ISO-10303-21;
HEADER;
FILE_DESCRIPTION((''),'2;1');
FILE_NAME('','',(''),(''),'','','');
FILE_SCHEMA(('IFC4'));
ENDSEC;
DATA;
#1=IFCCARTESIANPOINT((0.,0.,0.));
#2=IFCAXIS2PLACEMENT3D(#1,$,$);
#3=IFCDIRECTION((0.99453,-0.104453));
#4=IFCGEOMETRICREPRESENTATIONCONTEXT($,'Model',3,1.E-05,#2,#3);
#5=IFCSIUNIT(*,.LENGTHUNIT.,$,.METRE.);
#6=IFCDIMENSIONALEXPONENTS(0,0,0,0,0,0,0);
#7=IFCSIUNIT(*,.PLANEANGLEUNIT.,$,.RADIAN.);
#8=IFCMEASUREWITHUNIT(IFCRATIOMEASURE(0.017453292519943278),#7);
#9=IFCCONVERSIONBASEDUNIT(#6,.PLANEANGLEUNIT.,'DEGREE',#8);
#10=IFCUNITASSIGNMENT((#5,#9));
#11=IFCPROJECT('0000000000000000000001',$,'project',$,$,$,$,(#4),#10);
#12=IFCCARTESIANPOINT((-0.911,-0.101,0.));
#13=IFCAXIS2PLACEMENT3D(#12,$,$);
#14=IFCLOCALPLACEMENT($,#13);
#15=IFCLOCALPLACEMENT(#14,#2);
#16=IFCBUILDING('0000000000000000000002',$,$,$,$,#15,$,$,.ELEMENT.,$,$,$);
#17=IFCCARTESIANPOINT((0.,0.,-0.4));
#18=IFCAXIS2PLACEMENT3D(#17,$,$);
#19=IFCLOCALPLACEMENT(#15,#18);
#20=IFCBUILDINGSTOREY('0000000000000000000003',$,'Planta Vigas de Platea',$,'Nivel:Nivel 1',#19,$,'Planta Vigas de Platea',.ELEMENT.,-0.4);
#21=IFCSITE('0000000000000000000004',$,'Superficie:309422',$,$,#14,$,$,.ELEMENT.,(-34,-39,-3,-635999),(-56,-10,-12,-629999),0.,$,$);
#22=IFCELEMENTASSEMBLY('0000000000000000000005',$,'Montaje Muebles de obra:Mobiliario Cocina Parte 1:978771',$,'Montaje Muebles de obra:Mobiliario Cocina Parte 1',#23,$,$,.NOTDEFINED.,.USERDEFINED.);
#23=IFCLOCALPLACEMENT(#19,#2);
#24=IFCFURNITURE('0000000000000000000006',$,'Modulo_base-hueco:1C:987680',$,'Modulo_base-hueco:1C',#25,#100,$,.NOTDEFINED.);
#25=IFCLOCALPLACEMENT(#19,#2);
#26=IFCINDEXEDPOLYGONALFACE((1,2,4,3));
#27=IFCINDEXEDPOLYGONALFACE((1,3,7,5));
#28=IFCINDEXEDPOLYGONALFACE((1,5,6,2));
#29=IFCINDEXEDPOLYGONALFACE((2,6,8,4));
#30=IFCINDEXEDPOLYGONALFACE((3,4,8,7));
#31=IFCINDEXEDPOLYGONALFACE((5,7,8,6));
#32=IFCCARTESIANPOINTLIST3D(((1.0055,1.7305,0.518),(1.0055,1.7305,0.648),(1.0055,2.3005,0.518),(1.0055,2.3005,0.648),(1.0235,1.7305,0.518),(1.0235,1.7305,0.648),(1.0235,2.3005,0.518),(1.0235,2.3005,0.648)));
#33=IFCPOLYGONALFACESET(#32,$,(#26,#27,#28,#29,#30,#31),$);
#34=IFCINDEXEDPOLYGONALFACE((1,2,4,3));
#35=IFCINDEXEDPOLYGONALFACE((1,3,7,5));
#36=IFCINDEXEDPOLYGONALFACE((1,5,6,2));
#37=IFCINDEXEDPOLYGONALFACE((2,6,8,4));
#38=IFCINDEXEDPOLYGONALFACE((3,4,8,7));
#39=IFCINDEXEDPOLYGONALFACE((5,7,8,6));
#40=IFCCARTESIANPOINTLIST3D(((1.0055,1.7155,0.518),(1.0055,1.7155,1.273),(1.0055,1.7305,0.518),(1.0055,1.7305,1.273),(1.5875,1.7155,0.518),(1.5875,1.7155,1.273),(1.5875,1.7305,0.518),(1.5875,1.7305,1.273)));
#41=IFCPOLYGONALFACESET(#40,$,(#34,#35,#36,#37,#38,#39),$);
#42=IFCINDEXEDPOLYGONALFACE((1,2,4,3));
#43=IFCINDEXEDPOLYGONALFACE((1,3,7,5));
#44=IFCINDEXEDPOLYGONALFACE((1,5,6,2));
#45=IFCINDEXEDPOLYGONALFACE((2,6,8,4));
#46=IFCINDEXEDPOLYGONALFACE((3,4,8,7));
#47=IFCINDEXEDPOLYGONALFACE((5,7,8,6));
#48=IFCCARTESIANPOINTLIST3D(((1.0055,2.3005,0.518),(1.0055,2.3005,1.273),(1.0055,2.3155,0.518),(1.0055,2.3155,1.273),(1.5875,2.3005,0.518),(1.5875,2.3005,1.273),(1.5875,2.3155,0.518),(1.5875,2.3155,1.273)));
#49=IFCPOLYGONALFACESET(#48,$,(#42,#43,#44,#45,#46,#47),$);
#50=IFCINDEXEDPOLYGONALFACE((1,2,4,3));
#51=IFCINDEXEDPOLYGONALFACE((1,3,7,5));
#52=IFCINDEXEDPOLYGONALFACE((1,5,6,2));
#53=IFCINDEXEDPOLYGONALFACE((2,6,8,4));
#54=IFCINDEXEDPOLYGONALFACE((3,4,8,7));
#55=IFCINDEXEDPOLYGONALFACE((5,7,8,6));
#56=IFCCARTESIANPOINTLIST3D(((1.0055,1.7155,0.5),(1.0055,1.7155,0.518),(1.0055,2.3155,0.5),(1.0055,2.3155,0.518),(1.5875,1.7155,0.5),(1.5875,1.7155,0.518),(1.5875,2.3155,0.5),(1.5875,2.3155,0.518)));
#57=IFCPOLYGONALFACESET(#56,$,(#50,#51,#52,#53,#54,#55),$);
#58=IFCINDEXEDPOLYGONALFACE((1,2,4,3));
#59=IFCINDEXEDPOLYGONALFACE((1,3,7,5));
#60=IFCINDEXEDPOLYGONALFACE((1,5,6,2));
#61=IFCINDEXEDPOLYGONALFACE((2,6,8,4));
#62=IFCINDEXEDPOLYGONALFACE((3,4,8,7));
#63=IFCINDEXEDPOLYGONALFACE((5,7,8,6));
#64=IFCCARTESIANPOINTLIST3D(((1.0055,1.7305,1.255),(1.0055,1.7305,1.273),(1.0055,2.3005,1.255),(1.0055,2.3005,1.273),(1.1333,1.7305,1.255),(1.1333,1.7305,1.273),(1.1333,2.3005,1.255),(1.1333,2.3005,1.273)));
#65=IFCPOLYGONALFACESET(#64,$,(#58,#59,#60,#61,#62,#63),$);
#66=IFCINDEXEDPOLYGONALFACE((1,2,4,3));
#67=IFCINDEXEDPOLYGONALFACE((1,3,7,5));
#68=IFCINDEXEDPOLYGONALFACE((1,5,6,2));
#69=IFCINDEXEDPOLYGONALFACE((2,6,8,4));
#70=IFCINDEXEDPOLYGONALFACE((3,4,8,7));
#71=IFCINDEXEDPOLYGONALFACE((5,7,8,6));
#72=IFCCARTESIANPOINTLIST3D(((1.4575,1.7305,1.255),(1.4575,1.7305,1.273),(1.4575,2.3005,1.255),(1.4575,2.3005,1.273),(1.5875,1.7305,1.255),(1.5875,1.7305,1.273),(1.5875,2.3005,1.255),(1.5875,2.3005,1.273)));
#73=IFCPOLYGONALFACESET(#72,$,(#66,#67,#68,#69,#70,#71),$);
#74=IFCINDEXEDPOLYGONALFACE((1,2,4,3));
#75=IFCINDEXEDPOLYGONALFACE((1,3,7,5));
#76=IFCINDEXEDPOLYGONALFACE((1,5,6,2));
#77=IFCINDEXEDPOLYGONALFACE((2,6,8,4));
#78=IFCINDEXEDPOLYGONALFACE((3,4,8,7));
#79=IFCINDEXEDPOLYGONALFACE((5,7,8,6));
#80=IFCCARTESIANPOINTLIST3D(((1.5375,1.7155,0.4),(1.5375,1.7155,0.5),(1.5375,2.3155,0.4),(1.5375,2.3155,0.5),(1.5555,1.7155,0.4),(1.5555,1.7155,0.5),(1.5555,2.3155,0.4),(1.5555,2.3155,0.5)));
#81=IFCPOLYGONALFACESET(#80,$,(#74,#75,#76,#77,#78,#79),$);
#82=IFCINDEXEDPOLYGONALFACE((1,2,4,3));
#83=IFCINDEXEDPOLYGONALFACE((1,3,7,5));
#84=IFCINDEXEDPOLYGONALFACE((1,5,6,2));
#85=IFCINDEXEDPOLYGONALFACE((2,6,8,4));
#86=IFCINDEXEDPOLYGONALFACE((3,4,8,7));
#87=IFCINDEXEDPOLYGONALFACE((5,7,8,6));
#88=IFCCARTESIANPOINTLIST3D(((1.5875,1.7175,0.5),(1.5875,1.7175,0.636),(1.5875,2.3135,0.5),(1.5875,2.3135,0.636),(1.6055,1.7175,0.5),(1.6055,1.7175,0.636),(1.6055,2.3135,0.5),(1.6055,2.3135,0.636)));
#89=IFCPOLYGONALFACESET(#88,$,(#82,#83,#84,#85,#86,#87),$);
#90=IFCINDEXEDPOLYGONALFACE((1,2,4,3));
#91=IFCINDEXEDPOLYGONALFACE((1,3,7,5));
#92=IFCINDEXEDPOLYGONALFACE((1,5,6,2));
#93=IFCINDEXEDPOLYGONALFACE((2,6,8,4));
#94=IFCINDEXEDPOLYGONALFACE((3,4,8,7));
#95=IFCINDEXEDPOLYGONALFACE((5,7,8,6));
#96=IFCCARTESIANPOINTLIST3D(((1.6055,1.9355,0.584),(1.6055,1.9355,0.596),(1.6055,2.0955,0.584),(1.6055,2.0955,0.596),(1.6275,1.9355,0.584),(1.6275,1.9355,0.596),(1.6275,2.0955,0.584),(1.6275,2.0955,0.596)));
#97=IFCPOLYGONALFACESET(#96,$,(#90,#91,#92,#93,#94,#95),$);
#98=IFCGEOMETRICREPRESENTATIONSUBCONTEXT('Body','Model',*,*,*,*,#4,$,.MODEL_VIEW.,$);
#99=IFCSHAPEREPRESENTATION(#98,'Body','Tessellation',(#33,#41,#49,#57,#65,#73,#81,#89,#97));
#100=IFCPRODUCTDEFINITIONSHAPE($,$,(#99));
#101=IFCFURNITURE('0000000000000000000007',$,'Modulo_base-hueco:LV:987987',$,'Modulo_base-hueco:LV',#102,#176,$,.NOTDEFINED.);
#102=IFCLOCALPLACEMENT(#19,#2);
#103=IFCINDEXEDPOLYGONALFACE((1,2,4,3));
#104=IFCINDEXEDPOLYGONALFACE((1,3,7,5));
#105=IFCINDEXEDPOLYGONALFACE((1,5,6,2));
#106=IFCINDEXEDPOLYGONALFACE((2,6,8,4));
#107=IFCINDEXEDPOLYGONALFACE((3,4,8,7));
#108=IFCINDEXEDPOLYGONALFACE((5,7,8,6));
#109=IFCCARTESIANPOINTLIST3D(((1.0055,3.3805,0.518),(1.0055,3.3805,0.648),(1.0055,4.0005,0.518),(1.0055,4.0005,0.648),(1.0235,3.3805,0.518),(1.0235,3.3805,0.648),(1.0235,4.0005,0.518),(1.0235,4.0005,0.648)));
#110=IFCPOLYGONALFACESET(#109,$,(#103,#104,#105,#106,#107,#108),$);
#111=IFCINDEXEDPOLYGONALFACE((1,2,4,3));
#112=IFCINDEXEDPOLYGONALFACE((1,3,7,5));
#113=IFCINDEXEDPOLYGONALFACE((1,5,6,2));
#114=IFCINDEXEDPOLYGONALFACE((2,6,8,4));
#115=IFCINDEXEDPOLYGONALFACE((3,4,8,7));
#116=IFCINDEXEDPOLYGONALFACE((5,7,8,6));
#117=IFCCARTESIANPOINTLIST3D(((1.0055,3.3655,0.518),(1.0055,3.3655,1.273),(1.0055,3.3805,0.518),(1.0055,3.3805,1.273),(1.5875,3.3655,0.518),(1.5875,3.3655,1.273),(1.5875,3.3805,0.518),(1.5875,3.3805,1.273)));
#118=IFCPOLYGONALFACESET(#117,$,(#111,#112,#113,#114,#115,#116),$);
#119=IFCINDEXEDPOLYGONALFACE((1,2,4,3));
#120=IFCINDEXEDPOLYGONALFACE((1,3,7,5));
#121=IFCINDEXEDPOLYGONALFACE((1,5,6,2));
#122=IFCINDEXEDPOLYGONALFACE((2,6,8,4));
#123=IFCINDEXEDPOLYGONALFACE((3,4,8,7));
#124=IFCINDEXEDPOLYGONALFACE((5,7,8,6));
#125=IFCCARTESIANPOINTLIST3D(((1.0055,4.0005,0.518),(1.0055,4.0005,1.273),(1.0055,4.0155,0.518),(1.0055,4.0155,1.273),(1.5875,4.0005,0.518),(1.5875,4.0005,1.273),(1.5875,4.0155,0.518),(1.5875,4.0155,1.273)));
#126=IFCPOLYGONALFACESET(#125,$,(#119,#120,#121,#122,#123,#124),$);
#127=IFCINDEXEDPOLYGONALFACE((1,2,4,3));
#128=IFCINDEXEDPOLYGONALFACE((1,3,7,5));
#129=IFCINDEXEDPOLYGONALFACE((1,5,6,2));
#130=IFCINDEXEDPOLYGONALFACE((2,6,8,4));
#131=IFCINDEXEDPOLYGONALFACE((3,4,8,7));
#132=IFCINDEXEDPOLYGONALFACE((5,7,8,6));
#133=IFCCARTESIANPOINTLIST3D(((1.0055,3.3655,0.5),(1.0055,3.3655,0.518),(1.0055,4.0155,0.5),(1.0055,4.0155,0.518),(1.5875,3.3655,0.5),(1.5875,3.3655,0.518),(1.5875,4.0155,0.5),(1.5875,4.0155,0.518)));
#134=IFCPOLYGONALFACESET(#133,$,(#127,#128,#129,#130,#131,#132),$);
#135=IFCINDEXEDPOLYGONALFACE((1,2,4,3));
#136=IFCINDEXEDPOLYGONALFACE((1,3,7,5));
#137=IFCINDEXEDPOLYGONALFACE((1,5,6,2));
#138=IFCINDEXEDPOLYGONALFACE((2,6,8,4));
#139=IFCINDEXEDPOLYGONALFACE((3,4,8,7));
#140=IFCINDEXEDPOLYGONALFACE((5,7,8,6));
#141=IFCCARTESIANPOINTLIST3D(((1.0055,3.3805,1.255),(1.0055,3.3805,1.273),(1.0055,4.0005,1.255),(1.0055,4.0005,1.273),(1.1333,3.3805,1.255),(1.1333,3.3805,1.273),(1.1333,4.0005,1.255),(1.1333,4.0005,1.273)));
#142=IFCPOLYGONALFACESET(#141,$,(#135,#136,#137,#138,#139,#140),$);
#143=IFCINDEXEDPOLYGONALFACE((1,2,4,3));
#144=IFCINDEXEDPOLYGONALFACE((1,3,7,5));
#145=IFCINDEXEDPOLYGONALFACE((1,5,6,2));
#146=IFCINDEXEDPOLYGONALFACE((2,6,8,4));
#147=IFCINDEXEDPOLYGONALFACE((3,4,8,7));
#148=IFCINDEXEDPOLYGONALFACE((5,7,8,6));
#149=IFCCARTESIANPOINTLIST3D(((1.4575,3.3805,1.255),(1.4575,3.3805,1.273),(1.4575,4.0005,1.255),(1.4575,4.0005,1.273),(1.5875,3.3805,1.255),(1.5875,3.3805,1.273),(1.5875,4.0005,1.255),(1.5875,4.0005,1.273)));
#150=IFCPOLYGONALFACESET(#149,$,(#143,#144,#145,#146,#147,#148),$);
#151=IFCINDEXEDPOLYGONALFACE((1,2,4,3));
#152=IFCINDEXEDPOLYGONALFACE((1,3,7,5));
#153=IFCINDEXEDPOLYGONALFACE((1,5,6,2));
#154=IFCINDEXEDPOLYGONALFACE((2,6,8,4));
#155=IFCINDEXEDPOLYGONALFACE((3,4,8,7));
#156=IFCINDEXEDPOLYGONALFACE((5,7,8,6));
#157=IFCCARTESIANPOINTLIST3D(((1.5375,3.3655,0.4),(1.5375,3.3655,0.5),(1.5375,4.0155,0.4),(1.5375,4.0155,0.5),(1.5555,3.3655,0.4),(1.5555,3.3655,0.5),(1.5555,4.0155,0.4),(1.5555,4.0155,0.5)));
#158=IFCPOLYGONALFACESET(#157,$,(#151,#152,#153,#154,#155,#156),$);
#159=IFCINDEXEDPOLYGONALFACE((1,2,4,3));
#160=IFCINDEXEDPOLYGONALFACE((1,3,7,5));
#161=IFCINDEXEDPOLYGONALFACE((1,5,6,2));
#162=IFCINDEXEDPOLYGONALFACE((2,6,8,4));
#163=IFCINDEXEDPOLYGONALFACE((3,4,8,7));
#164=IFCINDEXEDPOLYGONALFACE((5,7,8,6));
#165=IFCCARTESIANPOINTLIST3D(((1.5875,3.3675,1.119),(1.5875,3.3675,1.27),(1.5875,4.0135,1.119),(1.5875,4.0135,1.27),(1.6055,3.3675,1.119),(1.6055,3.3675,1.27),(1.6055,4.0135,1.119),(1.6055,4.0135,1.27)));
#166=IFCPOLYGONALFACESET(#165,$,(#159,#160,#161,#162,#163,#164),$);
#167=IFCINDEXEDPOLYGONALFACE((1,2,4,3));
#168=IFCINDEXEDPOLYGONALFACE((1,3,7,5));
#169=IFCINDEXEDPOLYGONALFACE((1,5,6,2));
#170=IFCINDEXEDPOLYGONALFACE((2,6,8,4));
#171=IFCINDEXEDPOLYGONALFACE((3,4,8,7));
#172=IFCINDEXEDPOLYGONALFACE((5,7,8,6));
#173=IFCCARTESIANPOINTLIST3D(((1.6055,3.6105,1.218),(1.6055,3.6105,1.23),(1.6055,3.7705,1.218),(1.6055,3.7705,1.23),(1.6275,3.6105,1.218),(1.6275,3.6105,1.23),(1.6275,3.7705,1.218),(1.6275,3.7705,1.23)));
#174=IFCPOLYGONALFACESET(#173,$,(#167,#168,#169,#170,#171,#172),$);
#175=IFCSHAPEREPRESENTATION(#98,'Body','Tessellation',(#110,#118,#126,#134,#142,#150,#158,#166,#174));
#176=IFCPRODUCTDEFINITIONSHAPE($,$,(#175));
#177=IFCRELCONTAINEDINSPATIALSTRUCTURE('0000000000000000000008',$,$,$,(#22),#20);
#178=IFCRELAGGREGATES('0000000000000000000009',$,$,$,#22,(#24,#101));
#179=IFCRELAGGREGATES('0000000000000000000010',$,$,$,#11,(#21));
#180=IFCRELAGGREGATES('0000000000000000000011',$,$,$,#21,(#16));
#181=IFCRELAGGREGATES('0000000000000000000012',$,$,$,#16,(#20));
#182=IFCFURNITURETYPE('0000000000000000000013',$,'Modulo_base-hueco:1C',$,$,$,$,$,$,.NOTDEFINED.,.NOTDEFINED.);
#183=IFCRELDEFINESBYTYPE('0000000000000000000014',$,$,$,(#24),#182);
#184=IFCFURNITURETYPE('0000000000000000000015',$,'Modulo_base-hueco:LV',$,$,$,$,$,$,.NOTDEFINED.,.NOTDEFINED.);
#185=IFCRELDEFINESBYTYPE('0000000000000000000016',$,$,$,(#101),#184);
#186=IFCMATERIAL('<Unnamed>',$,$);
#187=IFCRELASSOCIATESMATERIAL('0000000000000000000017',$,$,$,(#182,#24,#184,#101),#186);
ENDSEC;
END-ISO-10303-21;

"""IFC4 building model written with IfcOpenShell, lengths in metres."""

from ifc_helpers import new_model, entity, si_unit, converted_unit, direction, frame, frame_2d, origin, origin_2d_with_axis, place, context, subcontext, project, spatial, rectangle, extrude, source, transform, mapped, material, type_object, type_shapes, element, aggregate, save


model = new_model("IFC4")

# Units and contexts
model_context = context("Model", 3, precision=1e-05, world=origin(), true_north=direction((0.99453, -0.104453)))
body_context = subcontext(model_context, "Body", "Model", "MODEL_VIEW")
ifc_project = project(units=[si_unit("LENGTHUNIT", "METRE"), converted_unit("PLANEANGLEUNIT", "DEGREE", entity("IfcRatioMeasure", 0.017453292519943278), si_unit("PLANEANGLEUNIT", "RADIAN"), dimensions=[0, 0, 0, 0, 0, 0, 0])], contexts=[model_context])

# Site, building, storey
site_placement = place(None, frame((-0.911, -0.101, 0.0)))
site = spatial("IfcSite", under=ifc_project, at=site_placement, Name="Superficie:309422", CompositionType="ELEMENT", RefLatitude=(-34, -39, -3, -635999), RefLongitude=(-56, -10, -12, -629999), RefElevation=0.0)
building_placement = place(site_placement, origin())
building = spatial("IfcBuilding", under=site, at=building_placement, CompositionType="ELEMENT")
storey_placement = place(building_placement, frame((0.0, 0.0, -0.4)))
storey = spatial("IfcBuildingStorey", under=building, at=storey_placement, Name="Planta Vigas de Platea", ObjectType="Nivel:Nivel 1", LongName="Planta Vigas de Platea", CompositionType="ELEMENT", Elevation=-0.4)

# Shared definitions
ifc_material_1 = material(Name="<Unnamed>")

# Element assembly, furniture
assembly_placement = place(storey_placement, origin())
assembly = element("IfcElementAssembly", 1, at=assembly_placement, inside=storey, Name="Montaje Muebles de obra:Mobiliario Cocina Parte 1:978771", ObjectType="Montaje Muebles de obra:Mobiliario Cocina Parte 1", AssemblyPlace="NOTDEFINED", PredefinedType="USERDEFINED")
furniture_type_1 = type_object("IfcFurnitureType", Name="Modulo_base-hueco:1C", AssemblyPlace="NOTDEFINED", PredefinedType="NOTDEFINED", material=ifc_material_1)
shared_shape_1 = source(origin(), body_context, "Body", "SweptSolid", [
    extrude(rectangle(XDim=0.57, YDim=0.018, at=frame_2d((0.0, 0.0), x_axis=(1.0, 0.0))), frame((0.009, 0.3, 0.118), z_axis=(0.0, 0.0, 1.0), x_axis=(0.0, -1.0, 0.0)), (0.0, 0.0, 1.0), 0.13),
    extrude(rectangle(XDim=0.015, YDim=0.582, at=origin_2d_with_axis()), frame((0.291, 0.0075, 0.118), z_axis=(0.0, 0.0, 1.0), x_axis=(0.0, -1.0, 0.0)), (0.0, 0.0, 1.0), 0.755),
    extrude(rectangle(XDim=0.015, YDim=0.582, at=frame_2d((0.0, 0.0), x_axis=(1.0, 0.0))), frame((0.291, 0.5925, 0.118), z_axis=(0.0, 0.0, 1.0), x_axis=(0.0, 1.0, 0.0)), (0.0, 0.0, 1.0), 0.755),
    extrude(rectangle(XDim=0.6, YDim=0.582, at=frame_2d((0.0, 0.0), x_axis=(1.0, 0.0))), frame((0.291, 0.3, 0.1), z_axis=(0.0, 0.0, 1.0), x_axis=(0.0, -1.0, 0.0)), (0.0, 0.0, 1.0), 0.018),
    extrude(rectangle(XDim=0.57, YDim=0.1278, at=origin_2d_with_axis()), frame((0.0639, 0.3, 0.855), z_axis=(0.0, 0.0, 1.0), x_axis=(0.0, -1.0, 0.0)), (0.0, 0.0, 1.0), 0.018),
    extrude(rectangle(XDim=0.57, YDim=0.13, at=frame_2d((0.0, 0.0), x_axis=(1.0, 0.0))), frame((0.517, 0.3, 0.855), z_axis=(0.0, 0.0, 1.0), x_axis=(0.0, -1.0, 0.0)), (0.0, 0.0, 1.0), 0.018),
    extrude(rectangle(XDim=0.018, YDim=0.6, at=frame_2d((0.0, 0.0), x_axis=(1.0, 0.0))), frame((0.541, 0.3, 0.0)), (0.0, 0.0, 1.0), 0.1),
    extrude(rectangle(XDim=0.018, YDim=0.596, at=origin_2d_with_axis()), frame((0.591, 0.3, 0.1), z_axis=(0.0, 0.0, 1.0), x_axis=(-1.0, 0.0, 0.0)), (0.0, 0.0, 1.0), 0.136),
    extrude(rectangle(XDim=0.022, YDim=0.16, at=frame_2d((0.0, 0.0), x_axis=(1.0, 0.0))), frame((0.611, 0.3, 0.184), z_axis=(0.0, 0.0, 1.0), x_axis=(-1.0, 0.0, 0.0)), (0.0, 0.0, 1.0), 0.012),
])
type_shapes(furniture_type_1, [shared_shape_1])
furniture_1_placement = place(assembly_placement, frame((1.0055, 1.7155, 0.4)))
furniture_1 = element("IfcFurniture", 2, at=furniture_1_placement, type_object=furniture_type_1, material=ifc_material_1, Name="Modulo_base-hueco:1C:987680", ObjectType="Modulo_base-hueco:1C", PredefinedType="NOTDEFINED", context=body_context, shape_type="MappedRepresentation", body=[
    mapped(shared_shape_1, transform((0.0, 0.0, 0.0), scale=1.0)),
])
furniture_type_2 = type_object("IfcFurnitureType", Name="Modulo_base-hueco:LV", AssemblyPlace="NOTDEFINED", PredefinedType="NOTDEFINED", material=ifc_material_1)
shared_shape_2 = source(origin(), body_context, "Body", "SweptSolid", [
    extrude(rectangle(XDim=0.62, YDim=0.018, at=origin_2d_with_axis()), frame((0.009, 0.325, 0.118), z_axis=(0.0, 0.0, 1.0), x_axis=(0.0, -1.0, 0.0)), (0.0, 0.0, 1.0), 0.13),
    extrude(rectangle(XDim=0.015, YDim=0.582, at=frame_2d((0.0, 0.0), x_axis=(1.0, 0.0))), frame((0.291, 0.0075, 0.118), z_axis=(0.0, 0.0, 1.0), x_axis=(0.0, -1.0, 0.0)), (0.0, 0.0, 1.0), 0.755),
    extrude(rectangle(XDim=0.015, YDim=0.582, at=frame_2d((0.0, 0.0), x_axis=(1.0, 0.0))), frame((0.291, 0.6425, 0.118), z_axis=(0.0, 0.0, 1.0), x_axis=(0.0, 1.0, 0.0)), (0.0, 0.0, 1.0), 0.755),
    extrude(rectangle(XDim=0.65, YDim=0.582, at=frame_2d((0.0, 0.0), x_axis=(1.0, 0.0))), frame((0.291, 0.325, 0.1), z_axis=(0.0, 0.0, 1.0), x_axis=(0.0, -1.0, 0.0)), (0.0, 0.0, 1.0), 0.018),
    extrude(rectangle(XDim=0.62, YDim=0.1278, at=frame_2d((0.0, 0.0), x_axis=(1.0, 0.0))), frame((0.0639, 0.325, 0.855), z_axis=(0.0, 0.0, 1.0), x_axis=(0.0, -1.0, 0.0)), (0.0, 0.0, 1.0), 0.018),
    extrude(rectangle(XDim=0.62, YDim=0.13, at=frame_2d((0.0, 0.0), x_axis=(1.0, 0.0))), frame((0.517, 0.325, 0.855), z_axis=(0.0, 0.0, 1.0), x_axis=(0.0, -1.0, 0.0)), (0.0, 0.0, 1.0), 0.018),
    extrude(rectangle(XDim=0.018, YDim=0.65, at=frame_2d((0.0, 0.0), x_axis=(1.0, 0.0))), frame((0.541, 0.325, 0.0)), (0.0, 0.0, 1.0), 0.1),
    extrude(rectangle(XDim=0.018, YDim=0.646, at=frame_2d((0.0, 0.0), x_axis=(1.0, 0.0))), frame((0.591, 0.325, 0.719), z_axis=(0.0, 0.0, 1.0), x_axis=(-1.0, 0.0, 0.0)), (0.0, 0.0, 1.0), 0.151),
    extrude(rectangle(XDim=0.022, YDim=0.16, at=frame_2d((0.0, 0.0), x_axis=(1.0, 0.0))), frame((0.611, 0.325, 0.818), z_axis=(0.0, 0.0, 1.0), x_axis=(-1.0, 0.0, 0.0)), (0.0, 0.0, 1.0), 0.012),
])
type_shapes(furniture_type_2, [shared_shape_2])
furniture_2_placement = place(assembly_placement, frame((1.0055, 3.3655, 0.4)))
furniture_2 = element("IfcFurniture", 3, at=furniture_2_placement, type_object=furniture_type_2, material=ifc_material_1, Name="Modulo_base-hueco:LV:987987", ObjectType="Modulo_base-hueco:LV", PredefinedType="NOTDEFINED", context=body_context, shape_type="MappedRepresentation", body=[
    mapped(shared_shape_2, transform((0.0, 0.0, 0.0), scale=1.0)),
])
aggregate(assembly, [furniture_1, furniture_2])

save(model, "model.ifc")
